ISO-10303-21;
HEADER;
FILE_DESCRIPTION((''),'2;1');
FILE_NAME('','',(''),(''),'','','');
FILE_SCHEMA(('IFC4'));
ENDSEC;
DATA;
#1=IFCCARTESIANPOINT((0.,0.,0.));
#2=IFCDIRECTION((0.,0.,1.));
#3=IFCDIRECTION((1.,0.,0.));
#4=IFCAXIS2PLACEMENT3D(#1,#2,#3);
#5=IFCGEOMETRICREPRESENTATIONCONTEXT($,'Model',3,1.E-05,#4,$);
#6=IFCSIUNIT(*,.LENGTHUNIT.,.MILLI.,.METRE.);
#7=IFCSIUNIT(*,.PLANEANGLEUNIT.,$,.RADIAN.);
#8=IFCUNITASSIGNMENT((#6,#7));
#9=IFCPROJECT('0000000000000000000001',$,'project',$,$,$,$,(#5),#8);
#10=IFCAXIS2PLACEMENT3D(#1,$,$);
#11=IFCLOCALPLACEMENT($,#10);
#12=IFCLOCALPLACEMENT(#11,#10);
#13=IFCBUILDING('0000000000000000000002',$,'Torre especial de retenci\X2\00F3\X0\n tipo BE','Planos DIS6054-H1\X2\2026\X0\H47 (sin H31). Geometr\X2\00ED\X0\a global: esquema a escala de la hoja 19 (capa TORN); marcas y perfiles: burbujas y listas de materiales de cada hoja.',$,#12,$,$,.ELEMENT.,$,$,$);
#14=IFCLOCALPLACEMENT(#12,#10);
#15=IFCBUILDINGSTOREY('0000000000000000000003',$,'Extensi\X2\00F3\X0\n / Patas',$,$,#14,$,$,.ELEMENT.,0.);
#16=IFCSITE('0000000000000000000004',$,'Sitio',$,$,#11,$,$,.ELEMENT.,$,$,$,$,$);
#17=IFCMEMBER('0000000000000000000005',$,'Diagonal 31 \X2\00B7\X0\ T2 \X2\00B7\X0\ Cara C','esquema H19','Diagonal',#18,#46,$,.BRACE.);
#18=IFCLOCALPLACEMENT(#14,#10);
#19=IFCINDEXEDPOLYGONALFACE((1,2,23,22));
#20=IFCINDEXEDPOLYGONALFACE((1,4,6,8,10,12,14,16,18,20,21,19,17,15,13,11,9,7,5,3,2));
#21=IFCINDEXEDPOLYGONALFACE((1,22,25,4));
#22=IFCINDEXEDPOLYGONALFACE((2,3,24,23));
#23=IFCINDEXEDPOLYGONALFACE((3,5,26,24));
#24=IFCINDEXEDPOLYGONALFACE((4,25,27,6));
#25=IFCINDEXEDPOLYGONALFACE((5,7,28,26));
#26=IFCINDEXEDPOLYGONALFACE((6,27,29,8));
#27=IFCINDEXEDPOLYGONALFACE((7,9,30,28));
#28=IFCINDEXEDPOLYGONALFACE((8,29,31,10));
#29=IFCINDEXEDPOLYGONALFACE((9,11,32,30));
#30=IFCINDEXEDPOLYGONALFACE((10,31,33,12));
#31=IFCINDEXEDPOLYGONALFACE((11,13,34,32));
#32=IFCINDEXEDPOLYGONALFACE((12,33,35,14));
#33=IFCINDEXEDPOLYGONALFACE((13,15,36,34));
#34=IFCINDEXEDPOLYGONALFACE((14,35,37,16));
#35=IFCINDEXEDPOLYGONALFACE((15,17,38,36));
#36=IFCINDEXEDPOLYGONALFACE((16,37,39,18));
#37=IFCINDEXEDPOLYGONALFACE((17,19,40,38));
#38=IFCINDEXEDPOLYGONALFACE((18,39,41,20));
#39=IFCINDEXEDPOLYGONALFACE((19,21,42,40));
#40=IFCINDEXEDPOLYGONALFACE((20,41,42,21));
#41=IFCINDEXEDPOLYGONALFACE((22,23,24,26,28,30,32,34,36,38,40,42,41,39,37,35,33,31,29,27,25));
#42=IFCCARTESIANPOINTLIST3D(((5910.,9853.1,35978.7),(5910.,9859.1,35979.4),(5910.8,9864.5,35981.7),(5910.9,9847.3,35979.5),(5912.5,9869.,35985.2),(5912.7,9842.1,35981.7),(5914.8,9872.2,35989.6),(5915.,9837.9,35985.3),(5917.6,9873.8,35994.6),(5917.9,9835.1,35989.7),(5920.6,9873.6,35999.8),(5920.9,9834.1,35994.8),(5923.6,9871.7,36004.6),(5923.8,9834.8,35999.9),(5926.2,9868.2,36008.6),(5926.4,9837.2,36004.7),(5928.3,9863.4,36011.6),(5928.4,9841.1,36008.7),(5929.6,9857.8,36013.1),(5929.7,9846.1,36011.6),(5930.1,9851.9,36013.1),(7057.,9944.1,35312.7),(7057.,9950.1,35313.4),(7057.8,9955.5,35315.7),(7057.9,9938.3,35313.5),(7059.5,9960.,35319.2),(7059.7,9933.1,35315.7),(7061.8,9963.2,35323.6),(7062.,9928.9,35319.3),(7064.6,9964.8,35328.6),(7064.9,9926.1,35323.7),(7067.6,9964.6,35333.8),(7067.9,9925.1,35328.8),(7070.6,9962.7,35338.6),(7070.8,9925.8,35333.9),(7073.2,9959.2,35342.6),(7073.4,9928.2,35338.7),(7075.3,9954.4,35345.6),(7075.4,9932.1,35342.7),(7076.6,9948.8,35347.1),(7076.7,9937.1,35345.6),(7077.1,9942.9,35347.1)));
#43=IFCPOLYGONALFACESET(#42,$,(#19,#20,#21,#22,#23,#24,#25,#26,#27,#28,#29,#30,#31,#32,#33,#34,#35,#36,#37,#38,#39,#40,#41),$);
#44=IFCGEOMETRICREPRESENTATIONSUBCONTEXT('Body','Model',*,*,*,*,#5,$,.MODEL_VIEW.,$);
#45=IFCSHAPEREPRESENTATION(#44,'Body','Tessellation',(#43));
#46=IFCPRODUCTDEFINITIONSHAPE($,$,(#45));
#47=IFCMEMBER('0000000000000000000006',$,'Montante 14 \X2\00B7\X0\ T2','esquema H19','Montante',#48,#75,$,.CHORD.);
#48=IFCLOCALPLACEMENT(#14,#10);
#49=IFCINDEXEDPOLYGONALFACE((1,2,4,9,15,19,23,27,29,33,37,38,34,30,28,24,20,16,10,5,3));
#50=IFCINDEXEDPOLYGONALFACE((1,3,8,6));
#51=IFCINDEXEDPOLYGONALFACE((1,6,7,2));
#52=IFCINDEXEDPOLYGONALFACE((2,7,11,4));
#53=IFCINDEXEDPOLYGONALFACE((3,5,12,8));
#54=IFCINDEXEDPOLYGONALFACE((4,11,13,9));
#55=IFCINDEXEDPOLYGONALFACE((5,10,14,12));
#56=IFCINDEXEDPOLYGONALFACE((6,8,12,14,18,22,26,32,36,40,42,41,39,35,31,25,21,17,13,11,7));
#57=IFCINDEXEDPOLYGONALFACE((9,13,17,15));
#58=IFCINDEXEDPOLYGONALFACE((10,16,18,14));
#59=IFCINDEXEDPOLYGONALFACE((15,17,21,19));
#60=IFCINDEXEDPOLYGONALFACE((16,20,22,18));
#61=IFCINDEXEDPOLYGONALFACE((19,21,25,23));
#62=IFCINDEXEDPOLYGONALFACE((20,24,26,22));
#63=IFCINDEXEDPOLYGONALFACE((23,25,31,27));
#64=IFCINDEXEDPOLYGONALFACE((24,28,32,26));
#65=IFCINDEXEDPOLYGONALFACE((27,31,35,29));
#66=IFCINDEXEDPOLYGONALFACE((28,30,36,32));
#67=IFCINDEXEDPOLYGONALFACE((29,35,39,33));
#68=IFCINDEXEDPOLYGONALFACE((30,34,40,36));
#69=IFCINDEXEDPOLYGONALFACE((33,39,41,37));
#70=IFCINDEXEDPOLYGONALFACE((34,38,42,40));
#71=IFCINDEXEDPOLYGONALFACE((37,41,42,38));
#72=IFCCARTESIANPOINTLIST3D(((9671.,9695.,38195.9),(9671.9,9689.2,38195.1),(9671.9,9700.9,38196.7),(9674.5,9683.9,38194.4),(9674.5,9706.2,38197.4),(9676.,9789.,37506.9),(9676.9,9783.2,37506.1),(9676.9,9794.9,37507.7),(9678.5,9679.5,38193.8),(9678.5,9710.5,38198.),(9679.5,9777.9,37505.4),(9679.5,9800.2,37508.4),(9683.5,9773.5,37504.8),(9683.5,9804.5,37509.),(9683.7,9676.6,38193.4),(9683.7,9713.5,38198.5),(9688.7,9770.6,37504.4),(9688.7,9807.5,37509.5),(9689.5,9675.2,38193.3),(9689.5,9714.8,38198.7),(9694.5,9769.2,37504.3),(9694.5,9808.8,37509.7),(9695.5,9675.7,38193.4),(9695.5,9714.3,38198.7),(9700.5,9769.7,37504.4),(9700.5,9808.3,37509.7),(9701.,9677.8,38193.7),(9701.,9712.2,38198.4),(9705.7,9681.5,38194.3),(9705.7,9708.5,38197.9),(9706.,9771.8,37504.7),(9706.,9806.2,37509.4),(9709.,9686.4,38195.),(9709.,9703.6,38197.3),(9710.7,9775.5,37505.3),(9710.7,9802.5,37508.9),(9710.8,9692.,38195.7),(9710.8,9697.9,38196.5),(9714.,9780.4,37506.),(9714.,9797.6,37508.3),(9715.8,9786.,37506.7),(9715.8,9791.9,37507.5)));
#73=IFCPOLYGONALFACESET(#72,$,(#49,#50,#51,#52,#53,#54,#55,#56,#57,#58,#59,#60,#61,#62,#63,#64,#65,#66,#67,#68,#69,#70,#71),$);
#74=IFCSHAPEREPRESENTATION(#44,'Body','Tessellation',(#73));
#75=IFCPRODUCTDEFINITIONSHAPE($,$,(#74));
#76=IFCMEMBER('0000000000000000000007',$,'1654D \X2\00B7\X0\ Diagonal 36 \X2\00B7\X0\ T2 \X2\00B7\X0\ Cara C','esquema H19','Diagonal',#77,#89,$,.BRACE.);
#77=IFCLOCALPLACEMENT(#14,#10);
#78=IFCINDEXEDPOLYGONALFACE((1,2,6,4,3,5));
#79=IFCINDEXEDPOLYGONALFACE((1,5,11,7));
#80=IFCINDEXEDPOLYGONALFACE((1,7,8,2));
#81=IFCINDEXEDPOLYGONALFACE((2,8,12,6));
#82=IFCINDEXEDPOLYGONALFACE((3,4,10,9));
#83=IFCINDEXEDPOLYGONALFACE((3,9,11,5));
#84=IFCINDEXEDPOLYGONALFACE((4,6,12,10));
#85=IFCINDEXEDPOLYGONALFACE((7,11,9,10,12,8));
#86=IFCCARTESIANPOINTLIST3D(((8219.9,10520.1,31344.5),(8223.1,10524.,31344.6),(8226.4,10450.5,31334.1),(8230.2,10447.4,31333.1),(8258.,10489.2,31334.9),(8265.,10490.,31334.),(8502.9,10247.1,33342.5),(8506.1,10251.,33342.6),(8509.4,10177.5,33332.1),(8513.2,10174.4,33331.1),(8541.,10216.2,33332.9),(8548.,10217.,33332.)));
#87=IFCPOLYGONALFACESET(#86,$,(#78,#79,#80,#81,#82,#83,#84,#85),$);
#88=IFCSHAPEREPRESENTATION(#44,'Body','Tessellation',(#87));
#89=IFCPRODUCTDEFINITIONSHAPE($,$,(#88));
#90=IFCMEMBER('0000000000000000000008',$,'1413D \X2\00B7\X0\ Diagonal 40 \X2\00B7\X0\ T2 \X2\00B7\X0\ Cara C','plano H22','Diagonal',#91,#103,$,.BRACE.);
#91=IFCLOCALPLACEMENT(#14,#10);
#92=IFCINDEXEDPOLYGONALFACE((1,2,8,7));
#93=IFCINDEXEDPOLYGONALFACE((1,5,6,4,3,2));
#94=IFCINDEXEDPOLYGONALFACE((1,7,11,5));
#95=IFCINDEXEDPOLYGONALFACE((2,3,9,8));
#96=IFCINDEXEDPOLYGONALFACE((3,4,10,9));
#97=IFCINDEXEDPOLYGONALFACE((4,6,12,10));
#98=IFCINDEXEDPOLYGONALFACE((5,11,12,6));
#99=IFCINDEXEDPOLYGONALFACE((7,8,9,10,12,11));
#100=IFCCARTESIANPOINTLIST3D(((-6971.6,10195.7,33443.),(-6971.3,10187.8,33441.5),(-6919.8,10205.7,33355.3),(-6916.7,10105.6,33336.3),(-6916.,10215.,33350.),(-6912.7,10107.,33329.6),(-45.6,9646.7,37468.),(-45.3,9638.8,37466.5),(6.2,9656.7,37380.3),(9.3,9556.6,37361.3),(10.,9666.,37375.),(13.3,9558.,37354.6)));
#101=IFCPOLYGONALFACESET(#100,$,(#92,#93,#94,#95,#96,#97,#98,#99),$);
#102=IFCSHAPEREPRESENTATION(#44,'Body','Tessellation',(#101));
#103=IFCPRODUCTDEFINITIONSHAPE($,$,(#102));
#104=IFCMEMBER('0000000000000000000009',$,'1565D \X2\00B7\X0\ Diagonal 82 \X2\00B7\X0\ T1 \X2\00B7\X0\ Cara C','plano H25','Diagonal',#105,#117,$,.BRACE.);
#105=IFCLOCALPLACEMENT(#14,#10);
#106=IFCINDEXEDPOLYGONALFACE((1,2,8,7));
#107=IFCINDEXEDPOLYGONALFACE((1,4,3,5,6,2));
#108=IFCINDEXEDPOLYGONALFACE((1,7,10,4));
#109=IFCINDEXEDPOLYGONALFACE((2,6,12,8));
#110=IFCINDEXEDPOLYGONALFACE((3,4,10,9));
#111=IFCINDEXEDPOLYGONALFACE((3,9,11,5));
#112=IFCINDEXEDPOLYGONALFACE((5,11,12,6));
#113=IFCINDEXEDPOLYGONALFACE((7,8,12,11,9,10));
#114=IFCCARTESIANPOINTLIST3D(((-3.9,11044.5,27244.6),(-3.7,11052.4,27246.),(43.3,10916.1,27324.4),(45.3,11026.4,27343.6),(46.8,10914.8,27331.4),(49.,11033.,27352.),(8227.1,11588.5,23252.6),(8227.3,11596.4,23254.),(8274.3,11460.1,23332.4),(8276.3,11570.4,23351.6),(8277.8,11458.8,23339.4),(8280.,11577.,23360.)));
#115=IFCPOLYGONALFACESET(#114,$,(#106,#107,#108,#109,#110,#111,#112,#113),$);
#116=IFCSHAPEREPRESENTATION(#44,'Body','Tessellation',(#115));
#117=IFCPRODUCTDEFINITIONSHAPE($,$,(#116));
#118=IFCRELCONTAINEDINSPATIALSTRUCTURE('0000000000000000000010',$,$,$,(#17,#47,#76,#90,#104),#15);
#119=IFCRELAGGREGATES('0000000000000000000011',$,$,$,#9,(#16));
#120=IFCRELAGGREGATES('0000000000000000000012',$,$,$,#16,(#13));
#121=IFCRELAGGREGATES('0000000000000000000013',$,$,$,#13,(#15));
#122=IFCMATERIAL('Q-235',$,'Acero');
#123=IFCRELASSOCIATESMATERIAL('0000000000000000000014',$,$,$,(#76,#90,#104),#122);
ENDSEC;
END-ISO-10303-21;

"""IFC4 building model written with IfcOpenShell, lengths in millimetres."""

from ifc_helpers import new_model, si_unit, frame, frame_2d, origin, origin_with_axes, place, context, subcontext, project, spatial, circle, l_section, extrude, material, element, save


model = new_model("IFC4")

# Units and contexts
model_context = context("Model", 3, precision=1e-05, world=origin_with_axes())
body_context = subcontext(model_context, "Body", "Model", "MODEL_VIEW")
ifc_project = project(units=[si_unit("LENGTHUNIT", "METRE", prefix="MILLI"), si_unit("PLANEANGLEUNIT", "RADIAN")], contexts=[model_context])

# Site, building, storey
site_placement = place(None, origin())
site = spatial("IfcSite", under=ifc_project, at=site_placement, Name="Sitio", CompositionType="ELEMENT")
building_placement = place(site_placement, origin())
building = spatial("IfcBuilding", under=site, at=building_placement, Name="Torre especial de retención tipo BE", Description="Planos DIS6054-H1…H47 (sin H31). Geometría global: esquema a escala de la hoja 19 (capa TORN); marcas y perfiles: burbujas y listas de materiales de cada hoja.", CompositionType="ELEMENT")
storey_placement = place(building_placement, origin())
storey = spatial("IfcBuildingStorey", under=building, at=storey_placement, Name="Extensión / Patas", CompositionType="ELEMENT", Elevation=0.0)

# Members
ifc_material = material(Name="Q-235", Category="Acero")
member_1_placement = place(storey_placement, frame((7067.0, 9945.0, 35330.0), z_axis=(-0.862761, -0.068449, 0.500958), x_axis=(-0.107151, -0.943537, -0.31346)))
element("IfcMember", 1, at=member_1_placement, inside=storey, Name="Diagonal 31 · T2 · Cara C", Description="esquema H19", ObjectType="Diagonal", PredefinedType="BRACE", context=body_context, shape_type="SweptSolid", body=[
    extrude(circle(Radius=20.0), None, (0.0, 0.0, 1.0), 1329.5),
])
member_2_placement = place(storey_placement, frame((9696.0, 9789.0, 37507.0), z_axis=(-0.00719, -0.135174, 0.990796), x_axis=(-0.999974, 0.000972, -0.007124)))
element("IfcMember", 2, at=member_2_placement, inside=storey, Name="Montante 14 · T2", Description="esquema H19", ObjectType="Montante", PredefinedType="CHORD", context=body_context, shape_type="SweptSolid", body=[
    extrude(circle(Radius=20.0), None, (0.0, 0.0, 1.0), 695.4),
])
member_3_placement = place(storey_placement, frame((8548.0, 10217.0, 33332.0), z_axis=(-0.138976, 0.134065, -0.981179), x_axis=(-0.63271, -0.77422, -0.016169)))
element("IfcMember", 3, at=member_3_placement, inside=storey, material=ifc_material, Name="1654D · Diagonal 36 · T2 · Cara C", Description="esquema H19", ObjectType="Diagonal", PredefinedType="BRACE", context=body_context, shape_type="SweptSolid", body=[
    extrude(l_section(Depth=55.0, Width=55.0, Thickness=5.0, at=frame_2d((27.5, 27.5))), None, (0.0, 0.0, 1.0), 2036.3),
])
member_4_placement = place(storey_placement, frame((10.0, 9666.0, 37375.0), z_axis=(-0.862578, 0.068374, -0.501282), x_axis=(0.030157, -0.982115, -0.185851)))
element("IfcMember", 4, at=member_4_placement, inside=storey, material=ifc_material, Name="1413D · Diagonal 40 · T2 · Cara C", Description="plano H22", ObjectType="Diagonal", PredefinedType="BRACE", context=body_context, shape_type="SweptSolid", body=[
    extrude(l_section(Depth=110.0, Width=110.0, Thickness=8.0, at=frame_2d((55.0, 55.0))), None, (0.0, 0.0, 1.0), 8029.4),
])
member_5_placement = place(storey_placement, frame((49.0, 11033.0, 27352.0), z_axis=(0.898175, 0.059362, -0.435611), x_axis=(-0.018033, -0.985034, -0.171415)))
element("IfcMember", 5, at=member_5_placement, inside=storey, material=ifc_material, Name="1565D · Diagonal 82 · T1 · Cara C", Description="plano H25", ObjectType="Diagonal", PredefinedType="BRACE", context=body_context, shape_type="SweptSolid", body=[
    extrude(l_section(Depth=120.0, Width=120.0, Thickness=8.0, at=frame_2d((60.0, 60.0))), None, (0.0, 0.0, 1.0), 9164.1),
])

save(model, "model.ifc")
